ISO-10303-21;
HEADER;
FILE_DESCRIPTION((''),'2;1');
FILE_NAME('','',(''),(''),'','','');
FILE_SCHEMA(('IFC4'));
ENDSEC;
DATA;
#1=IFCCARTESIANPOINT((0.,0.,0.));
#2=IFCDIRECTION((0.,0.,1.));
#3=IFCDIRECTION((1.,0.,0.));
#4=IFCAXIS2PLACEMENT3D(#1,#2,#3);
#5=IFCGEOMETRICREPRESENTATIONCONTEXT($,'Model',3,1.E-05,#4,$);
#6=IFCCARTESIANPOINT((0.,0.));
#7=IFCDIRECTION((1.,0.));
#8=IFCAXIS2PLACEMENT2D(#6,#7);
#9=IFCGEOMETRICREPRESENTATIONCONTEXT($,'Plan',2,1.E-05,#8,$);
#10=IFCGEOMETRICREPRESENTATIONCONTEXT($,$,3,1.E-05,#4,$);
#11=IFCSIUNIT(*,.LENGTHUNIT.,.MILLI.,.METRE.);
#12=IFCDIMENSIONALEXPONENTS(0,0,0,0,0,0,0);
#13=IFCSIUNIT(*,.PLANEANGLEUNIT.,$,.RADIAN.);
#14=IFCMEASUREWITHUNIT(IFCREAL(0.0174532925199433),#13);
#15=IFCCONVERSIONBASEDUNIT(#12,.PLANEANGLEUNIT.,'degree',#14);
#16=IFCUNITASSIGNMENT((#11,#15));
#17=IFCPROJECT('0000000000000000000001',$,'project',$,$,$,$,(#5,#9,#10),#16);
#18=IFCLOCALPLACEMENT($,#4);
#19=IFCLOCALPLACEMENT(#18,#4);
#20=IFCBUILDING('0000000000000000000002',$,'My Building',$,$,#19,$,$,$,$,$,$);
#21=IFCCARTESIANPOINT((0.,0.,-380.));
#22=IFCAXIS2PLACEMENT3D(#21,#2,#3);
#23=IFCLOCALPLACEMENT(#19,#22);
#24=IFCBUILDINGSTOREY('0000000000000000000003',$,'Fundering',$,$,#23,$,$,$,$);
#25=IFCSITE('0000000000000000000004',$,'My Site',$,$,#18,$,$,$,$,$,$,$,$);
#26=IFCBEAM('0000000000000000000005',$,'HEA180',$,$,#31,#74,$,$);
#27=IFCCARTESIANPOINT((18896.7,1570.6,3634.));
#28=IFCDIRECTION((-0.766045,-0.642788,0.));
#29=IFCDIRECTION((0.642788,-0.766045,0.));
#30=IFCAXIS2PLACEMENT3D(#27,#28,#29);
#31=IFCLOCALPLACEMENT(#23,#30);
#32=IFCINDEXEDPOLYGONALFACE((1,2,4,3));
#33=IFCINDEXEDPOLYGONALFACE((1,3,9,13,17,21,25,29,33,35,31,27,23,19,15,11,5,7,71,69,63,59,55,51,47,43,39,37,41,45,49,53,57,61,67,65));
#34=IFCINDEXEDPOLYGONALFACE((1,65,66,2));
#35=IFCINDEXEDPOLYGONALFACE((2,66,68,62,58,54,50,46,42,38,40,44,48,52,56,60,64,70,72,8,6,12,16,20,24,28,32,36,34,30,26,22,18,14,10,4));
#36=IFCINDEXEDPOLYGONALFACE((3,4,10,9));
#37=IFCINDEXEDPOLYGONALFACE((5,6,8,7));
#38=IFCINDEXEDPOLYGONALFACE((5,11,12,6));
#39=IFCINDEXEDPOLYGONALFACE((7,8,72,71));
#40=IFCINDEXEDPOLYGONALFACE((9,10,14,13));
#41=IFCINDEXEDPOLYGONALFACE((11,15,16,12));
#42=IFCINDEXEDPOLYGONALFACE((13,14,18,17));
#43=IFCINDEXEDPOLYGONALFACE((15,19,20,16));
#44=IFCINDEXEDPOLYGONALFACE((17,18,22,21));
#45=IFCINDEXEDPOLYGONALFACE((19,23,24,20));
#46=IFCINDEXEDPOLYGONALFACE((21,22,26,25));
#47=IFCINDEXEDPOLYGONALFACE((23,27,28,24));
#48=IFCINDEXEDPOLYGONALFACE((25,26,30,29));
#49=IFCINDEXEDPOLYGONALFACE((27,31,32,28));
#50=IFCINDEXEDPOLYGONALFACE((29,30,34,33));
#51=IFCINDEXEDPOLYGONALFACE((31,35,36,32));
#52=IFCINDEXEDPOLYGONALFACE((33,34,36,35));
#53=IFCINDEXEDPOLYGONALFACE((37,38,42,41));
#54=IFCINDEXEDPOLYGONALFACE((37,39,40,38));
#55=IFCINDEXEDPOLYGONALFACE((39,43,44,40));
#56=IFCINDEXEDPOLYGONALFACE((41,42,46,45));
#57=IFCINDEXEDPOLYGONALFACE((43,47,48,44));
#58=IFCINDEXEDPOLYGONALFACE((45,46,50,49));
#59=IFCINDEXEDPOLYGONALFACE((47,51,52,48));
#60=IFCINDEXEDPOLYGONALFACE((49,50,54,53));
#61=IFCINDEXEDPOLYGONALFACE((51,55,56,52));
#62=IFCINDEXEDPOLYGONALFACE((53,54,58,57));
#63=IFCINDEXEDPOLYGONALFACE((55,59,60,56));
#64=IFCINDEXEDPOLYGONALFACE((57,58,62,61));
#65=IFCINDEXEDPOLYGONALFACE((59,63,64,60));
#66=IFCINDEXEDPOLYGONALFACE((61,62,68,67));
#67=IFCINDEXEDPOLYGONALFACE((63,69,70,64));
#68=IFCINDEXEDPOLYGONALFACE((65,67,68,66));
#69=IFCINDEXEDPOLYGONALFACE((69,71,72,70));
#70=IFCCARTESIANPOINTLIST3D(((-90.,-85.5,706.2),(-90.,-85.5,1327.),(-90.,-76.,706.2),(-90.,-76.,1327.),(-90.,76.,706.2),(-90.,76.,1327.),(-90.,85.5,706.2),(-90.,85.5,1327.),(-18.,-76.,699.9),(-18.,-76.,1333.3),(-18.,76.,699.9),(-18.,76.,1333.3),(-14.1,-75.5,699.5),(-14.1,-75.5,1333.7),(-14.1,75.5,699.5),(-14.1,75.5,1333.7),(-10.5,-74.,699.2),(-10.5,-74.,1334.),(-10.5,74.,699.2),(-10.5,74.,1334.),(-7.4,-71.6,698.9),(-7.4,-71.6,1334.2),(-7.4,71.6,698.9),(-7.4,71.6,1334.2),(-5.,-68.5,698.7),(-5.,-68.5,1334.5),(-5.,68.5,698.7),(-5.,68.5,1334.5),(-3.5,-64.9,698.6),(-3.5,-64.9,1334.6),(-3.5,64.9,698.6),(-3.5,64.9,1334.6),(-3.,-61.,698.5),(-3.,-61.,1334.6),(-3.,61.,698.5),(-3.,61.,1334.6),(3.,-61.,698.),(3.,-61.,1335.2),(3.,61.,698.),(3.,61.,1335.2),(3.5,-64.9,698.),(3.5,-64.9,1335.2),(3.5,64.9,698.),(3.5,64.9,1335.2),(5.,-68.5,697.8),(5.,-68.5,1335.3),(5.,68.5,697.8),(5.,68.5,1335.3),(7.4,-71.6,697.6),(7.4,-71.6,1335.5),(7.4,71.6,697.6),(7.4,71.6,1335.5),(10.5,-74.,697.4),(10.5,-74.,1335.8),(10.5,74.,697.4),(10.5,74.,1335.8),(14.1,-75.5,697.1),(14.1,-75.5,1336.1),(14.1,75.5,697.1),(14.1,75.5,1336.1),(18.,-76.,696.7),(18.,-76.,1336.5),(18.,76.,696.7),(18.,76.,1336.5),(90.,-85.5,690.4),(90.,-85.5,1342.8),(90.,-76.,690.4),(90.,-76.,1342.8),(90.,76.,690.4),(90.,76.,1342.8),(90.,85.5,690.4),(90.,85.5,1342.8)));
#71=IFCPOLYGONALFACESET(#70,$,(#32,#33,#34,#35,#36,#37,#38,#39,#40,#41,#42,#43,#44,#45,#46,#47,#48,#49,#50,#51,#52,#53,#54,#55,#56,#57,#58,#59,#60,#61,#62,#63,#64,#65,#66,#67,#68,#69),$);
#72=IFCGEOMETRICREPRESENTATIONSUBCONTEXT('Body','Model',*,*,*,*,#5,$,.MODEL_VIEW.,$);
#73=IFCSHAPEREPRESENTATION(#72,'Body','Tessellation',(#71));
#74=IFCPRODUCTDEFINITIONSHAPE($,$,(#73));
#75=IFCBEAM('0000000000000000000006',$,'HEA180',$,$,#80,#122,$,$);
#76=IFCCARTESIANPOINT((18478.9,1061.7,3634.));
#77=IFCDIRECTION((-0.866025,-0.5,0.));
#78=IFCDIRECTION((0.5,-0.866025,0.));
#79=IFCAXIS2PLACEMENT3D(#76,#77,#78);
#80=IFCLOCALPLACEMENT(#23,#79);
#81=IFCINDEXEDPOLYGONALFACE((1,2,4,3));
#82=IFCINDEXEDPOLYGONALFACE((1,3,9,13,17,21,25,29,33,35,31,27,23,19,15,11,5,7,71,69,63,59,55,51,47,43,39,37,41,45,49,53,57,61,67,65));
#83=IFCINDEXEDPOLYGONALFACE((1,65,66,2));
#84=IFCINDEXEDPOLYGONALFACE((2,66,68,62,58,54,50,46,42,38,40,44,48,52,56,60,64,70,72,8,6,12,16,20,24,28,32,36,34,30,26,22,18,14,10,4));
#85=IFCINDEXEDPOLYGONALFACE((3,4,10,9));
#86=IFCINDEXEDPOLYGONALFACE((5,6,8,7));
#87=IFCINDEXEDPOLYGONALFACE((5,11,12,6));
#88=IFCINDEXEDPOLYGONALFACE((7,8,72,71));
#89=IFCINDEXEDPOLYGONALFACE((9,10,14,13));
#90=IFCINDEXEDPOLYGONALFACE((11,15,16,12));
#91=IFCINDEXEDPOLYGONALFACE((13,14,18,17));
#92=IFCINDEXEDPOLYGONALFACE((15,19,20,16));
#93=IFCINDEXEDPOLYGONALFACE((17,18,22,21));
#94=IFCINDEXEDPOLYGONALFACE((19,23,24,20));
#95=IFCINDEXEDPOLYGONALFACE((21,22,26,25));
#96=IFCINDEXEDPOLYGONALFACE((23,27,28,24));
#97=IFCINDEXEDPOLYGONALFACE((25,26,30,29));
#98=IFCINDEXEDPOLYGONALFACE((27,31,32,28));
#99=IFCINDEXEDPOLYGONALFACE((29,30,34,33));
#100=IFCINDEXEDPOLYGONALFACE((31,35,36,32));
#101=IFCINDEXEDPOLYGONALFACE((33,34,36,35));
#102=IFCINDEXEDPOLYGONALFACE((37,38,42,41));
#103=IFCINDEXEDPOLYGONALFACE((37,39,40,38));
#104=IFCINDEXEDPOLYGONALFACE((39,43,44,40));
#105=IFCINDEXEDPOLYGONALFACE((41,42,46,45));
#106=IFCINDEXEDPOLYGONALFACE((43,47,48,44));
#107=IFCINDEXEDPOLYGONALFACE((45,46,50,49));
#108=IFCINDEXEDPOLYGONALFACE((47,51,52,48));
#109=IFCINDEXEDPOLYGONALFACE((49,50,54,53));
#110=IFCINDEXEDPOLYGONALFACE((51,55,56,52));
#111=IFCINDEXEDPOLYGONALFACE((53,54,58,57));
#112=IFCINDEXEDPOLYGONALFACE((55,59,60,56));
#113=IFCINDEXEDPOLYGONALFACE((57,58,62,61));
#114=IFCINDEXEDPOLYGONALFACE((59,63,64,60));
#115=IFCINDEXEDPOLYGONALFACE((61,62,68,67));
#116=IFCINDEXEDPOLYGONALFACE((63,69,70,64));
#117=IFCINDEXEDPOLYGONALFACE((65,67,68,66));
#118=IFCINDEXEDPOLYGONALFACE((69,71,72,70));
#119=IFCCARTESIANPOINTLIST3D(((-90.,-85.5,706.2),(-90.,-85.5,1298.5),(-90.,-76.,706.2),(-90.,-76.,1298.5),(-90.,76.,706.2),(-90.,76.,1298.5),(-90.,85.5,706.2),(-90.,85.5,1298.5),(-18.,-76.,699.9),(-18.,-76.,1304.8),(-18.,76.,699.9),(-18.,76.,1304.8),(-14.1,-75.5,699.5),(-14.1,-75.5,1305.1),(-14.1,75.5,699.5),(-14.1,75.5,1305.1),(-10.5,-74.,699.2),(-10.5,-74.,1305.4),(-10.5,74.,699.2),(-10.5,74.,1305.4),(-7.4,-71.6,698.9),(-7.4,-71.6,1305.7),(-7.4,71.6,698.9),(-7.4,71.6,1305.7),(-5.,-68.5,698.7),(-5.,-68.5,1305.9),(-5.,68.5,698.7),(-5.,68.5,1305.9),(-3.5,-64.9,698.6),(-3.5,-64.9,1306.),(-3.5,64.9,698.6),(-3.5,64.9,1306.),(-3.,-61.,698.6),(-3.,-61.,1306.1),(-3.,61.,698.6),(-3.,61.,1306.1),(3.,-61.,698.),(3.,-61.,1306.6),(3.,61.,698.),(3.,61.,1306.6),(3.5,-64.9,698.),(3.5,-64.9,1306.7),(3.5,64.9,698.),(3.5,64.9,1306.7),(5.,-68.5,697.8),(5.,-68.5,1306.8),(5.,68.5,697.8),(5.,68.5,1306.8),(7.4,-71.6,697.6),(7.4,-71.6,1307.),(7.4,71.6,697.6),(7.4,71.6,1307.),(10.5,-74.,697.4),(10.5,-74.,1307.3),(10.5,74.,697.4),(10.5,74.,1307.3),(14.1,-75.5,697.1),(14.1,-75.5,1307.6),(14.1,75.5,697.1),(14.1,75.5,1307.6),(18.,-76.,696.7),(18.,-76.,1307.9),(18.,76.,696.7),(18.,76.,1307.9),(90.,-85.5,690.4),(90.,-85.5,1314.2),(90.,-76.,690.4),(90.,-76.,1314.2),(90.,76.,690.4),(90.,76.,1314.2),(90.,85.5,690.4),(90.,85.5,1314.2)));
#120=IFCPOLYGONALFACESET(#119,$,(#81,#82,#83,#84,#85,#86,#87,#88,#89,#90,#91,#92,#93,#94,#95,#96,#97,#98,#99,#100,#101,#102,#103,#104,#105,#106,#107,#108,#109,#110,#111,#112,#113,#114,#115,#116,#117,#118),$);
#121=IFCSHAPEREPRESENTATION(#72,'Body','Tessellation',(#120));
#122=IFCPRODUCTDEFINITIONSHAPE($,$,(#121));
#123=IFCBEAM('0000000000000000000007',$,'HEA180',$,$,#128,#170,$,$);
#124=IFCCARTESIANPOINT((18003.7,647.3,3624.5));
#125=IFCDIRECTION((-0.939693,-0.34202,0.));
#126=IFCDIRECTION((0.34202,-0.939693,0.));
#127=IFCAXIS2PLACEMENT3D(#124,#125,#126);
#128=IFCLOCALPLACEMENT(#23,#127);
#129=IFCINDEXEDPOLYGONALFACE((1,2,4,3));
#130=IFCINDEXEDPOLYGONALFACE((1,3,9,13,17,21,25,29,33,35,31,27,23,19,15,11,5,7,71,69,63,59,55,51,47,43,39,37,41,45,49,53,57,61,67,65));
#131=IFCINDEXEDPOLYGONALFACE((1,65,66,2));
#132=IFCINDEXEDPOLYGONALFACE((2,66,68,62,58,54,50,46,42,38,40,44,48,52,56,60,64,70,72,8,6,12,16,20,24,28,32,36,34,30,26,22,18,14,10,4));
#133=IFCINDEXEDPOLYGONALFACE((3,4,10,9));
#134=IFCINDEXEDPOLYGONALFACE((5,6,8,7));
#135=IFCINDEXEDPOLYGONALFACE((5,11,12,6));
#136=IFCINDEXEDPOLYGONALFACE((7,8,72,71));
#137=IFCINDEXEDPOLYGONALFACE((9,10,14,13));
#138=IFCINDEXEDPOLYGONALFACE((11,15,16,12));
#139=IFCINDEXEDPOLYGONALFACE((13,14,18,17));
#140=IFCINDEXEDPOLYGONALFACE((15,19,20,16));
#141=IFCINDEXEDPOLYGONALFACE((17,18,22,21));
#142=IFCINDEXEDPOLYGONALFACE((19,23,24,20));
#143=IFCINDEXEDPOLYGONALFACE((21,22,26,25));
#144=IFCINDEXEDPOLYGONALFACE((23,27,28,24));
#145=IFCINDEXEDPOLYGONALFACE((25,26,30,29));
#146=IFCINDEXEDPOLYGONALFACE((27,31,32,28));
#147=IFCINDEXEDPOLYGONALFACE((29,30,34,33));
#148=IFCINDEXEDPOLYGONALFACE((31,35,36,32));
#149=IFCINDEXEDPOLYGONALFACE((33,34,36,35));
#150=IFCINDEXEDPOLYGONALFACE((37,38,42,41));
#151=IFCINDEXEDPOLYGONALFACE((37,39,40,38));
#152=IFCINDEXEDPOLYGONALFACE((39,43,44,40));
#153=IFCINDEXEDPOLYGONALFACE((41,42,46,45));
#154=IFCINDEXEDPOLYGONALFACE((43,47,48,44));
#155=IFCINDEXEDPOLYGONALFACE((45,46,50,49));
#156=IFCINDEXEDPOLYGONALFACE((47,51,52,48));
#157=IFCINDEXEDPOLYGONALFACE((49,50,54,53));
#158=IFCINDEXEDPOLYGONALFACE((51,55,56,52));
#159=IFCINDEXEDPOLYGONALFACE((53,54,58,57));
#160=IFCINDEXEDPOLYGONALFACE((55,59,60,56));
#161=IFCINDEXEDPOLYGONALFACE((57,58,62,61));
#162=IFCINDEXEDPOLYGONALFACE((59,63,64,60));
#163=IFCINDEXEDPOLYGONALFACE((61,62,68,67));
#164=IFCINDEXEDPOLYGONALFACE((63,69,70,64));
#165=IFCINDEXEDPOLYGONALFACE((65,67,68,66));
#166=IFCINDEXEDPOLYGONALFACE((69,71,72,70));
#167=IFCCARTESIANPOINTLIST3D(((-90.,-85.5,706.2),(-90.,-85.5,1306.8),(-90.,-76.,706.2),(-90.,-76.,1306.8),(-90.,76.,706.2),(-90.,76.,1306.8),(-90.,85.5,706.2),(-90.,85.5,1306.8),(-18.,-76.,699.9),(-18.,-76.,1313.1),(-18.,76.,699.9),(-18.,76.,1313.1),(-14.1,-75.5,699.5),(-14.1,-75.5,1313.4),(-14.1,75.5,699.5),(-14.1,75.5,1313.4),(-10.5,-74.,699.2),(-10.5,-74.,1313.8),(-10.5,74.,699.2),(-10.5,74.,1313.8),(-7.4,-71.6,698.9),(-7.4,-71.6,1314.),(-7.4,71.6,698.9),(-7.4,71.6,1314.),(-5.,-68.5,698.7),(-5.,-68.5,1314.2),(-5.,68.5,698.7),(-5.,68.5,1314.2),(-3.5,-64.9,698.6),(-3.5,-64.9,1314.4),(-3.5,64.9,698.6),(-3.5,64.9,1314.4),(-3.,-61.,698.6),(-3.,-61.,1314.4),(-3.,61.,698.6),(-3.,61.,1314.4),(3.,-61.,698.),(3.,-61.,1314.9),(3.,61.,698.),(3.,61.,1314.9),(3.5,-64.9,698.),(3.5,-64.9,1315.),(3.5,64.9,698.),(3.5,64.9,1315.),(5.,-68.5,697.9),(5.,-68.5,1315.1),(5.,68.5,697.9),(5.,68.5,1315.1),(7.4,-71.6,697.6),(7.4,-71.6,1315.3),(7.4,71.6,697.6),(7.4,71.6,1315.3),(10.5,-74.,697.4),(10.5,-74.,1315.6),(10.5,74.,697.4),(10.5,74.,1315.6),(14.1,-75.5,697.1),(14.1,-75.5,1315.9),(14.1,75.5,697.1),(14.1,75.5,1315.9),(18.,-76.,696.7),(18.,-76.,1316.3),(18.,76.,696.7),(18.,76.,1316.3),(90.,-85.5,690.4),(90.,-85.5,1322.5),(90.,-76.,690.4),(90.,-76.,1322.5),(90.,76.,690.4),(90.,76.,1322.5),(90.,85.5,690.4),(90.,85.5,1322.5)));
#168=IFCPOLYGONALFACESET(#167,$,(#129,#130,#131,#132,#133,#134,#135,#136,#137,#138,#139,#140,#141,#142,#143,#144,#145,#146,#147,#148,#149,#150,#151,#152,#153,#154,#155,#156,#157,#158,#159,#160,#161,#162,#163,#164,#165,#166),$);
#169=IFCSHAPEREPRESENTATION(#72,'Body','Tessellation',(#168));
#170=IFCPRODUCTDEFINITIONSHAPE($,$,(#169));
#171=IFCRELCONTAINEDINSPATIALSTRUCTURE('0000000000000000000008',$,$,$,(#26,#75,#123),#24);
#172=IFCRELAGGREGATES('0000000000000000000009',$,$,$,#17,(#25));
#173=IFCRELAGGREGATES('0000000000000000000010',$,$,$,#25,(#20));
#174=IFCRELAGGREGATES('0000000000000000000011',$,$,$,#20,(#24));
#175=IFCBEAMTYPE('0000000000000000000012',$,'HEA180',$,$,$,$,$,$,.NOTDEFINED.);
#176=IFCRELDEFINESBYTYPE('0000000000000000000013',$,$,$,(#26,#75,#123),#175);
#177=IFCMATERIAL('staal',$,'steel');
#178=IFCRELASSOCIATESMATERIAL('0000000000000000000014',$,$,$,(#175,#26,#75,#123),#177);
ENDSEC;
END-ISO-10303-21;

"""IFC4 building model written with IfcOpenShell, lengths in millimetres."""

from ifc_helpers import new_model, entity, si_unit, converted_unit, frame, origin_with_axes, origin_2d_with_axis, place, context, subcontext, project, spatial, i_section, extrude, clip, halfspace, material, material_profile, profile_set, profile_usage, type_object, element, save


model = new_model("IFC4")

# Units and contexts
model_context = context("Model", 3, precision=1e-05, world=origin_with_axes())
plan_context = context("Plan", 2, precision=1e-05, world=origin_2d_with_axis())
context_of_model = context(None, 3, precision=1e-05, world=origin_with_axes())
body_context = subcontext(model_context, "Body", "Model", "MODEL_VIEW")
ifc_project = project(units=[si_unit("LENGTHUNIT", "METRE", prefix="MILLI"), converted_unit("PLANEANGLEUNIT", "degree", entity("IfcReal", 0.0174532925199433), si_unit("PLANEANGLEUNIT", "RADIAN"), dimensions=[0, 0, 0, 0, 0, 0, 0])], contexts=[model_context, plan_context, context_of_model])

# Site, building, storey
site_placement = place(None, origin_with_axes())
site = spatial("IfcSite", under=ifc_project, at=site_placement, Name="My Site")
building_placement = place(site_placement, origin_with_axes())
building = spatial("IfcBuilding", under=site, at=building_placement, Name="My Building")
storey_placement = place(building_placement, frame((0.0, 0.0, -380.0), z_axis=(0.0, 0.0, 1.0), x_axis=(1.0, 0.0, 0.0)))
storey = spatial("IfcBuildingStorey", under=building, at=storey_placement, Name="Fundering")

# Shared definitions
ifc_material_1 = material(Name="staal", Category="steel")

# Beams
ifc_material_profile_1 = material_profile(ifc_material_1, i_section(OverallWidth=180.0, OverallDepth=171.0, WebThickness=6.0, FlangeThickness=9.5, FilletRadius=15.0))
ifc_profile_set_1 = profile_set([ifc_material_profile_1], Name="HEA180")
beam_type_1 = type_object("IfcBeamType", Name="HEA180", PredefinedType="NOTDEFINED", material=ifc_profile_set_1)
ifc_profile_usage_1 = profile_usage(ifc_profile_set_1)
beam_1_placement = place(storey_placement, frame((18896.7, 1570.6, 3634.0), z_axis=(-0.766045, -0.642788, 0.0), x_axis=(0.642788, -0.766045, 0.0)))
element("IfcBeam", 1, at=beam_1_placement, inside=storey, type_object=beam_type_1, material=ifc_profile_usage_1, Name="HEA180", context=body_context, shape_type="Clipping", body=[
    clip(clip(extrude(i_section(OverallWidth=180.0, OverallDepth=171.0, WebThickness=6.0, FlangeThickness=9.5, FilletRadius=15.0), origin_with_axes(), (0.0, 0.0, 1.0), 2033.2), halfspace(frame((90.0, -3254.0, 690.4), z_axis=(-0.087118, 0.0, -0.996198), x_axis=(0.000001, 1.0, 0.0)), False)), halfspace(frame((90.0, -3254.0, 1342.8), z_axis=(-0.087142, 0.0, 0.996196), x_axis=(0.000003, 1.0, 0.0)), False)),
])
ifc_profile_usage_2 = profile_usage(ifc_profile_set_1)
beam_2_placement = place(storey_placement, frame((18478.9, 1061.7, 3634.0), z_axis=(-0.866025, -0.5, 0.0), x_axis=(0.5, -0.866025, 0.0)))
element("IfcBeam", 2, at=beam_2_placement, inside=storey, type_object=beam_type_1, material=ifc_profile_usage_2, Name="HEA180", context=body_context, shape_type="Clipping", body=[
    clip(clip(extrude(i_section(OverallWidth=180.0, OverallDepth=171.0, WebThickness=6.0, FlangeThickness=9.5, FilletRadius=15.0), origin_with_axes(), (0.0, 0.0, 1.0), 2004.6), halfspace(frame((90.0, -3235.0, 690.4), z_axis=(-0.087185, 0.0, -0.996192), x_axis=(-0.000003, 1.0, 0.0)), False)), halfspace(frame((90.0, -3235.0, 1314.2), z_axis=(-0.087181, -0.000001, 0.996192), x_axis=(-0.000007, 1.0, 0.0)), False)),
])
ifc_profile_usage_3 = profile_usage(ifc_profile_set_1)
beam_3_placement = place(storey_placement, frame((18003.7, 647.3, 3624.5), z_axis=(-0.939693, -0.34202, 0.0), x_axis=(0.34202, -0.939693, 0.0)))
element("IfcBeam", 3, at=beam_3_placement, inside=storey, type_object=beam_type_1, material=ifc_profile_usage_3, Name="HEA180", context=body_context, shape_type="Clipping", body=[
    clip(clip(extrude(i_section(OverallWidth=180.0, OverallDepth=171.0, WebThickness=6.0, FlangeThickness=9.5, FilletRadius=15.0), origin_with_axes(), (0.0, 0.0, 1.0), 2013.0), halfspace(frame((90.0, -3244.5, 690.4), z_axis=(-0.087145, 0.000001, -0.996196), x_axis=(0.000007, 1.0, 0.0)), False)), halfspace(frame((90.0, -3244.5, 1322.5), z_axis=(-0.08715, 0.0, 0.996195), x_axis=(0.000001, 1.0, 0.0)), False)),
])

save(model, "model.ifc")
